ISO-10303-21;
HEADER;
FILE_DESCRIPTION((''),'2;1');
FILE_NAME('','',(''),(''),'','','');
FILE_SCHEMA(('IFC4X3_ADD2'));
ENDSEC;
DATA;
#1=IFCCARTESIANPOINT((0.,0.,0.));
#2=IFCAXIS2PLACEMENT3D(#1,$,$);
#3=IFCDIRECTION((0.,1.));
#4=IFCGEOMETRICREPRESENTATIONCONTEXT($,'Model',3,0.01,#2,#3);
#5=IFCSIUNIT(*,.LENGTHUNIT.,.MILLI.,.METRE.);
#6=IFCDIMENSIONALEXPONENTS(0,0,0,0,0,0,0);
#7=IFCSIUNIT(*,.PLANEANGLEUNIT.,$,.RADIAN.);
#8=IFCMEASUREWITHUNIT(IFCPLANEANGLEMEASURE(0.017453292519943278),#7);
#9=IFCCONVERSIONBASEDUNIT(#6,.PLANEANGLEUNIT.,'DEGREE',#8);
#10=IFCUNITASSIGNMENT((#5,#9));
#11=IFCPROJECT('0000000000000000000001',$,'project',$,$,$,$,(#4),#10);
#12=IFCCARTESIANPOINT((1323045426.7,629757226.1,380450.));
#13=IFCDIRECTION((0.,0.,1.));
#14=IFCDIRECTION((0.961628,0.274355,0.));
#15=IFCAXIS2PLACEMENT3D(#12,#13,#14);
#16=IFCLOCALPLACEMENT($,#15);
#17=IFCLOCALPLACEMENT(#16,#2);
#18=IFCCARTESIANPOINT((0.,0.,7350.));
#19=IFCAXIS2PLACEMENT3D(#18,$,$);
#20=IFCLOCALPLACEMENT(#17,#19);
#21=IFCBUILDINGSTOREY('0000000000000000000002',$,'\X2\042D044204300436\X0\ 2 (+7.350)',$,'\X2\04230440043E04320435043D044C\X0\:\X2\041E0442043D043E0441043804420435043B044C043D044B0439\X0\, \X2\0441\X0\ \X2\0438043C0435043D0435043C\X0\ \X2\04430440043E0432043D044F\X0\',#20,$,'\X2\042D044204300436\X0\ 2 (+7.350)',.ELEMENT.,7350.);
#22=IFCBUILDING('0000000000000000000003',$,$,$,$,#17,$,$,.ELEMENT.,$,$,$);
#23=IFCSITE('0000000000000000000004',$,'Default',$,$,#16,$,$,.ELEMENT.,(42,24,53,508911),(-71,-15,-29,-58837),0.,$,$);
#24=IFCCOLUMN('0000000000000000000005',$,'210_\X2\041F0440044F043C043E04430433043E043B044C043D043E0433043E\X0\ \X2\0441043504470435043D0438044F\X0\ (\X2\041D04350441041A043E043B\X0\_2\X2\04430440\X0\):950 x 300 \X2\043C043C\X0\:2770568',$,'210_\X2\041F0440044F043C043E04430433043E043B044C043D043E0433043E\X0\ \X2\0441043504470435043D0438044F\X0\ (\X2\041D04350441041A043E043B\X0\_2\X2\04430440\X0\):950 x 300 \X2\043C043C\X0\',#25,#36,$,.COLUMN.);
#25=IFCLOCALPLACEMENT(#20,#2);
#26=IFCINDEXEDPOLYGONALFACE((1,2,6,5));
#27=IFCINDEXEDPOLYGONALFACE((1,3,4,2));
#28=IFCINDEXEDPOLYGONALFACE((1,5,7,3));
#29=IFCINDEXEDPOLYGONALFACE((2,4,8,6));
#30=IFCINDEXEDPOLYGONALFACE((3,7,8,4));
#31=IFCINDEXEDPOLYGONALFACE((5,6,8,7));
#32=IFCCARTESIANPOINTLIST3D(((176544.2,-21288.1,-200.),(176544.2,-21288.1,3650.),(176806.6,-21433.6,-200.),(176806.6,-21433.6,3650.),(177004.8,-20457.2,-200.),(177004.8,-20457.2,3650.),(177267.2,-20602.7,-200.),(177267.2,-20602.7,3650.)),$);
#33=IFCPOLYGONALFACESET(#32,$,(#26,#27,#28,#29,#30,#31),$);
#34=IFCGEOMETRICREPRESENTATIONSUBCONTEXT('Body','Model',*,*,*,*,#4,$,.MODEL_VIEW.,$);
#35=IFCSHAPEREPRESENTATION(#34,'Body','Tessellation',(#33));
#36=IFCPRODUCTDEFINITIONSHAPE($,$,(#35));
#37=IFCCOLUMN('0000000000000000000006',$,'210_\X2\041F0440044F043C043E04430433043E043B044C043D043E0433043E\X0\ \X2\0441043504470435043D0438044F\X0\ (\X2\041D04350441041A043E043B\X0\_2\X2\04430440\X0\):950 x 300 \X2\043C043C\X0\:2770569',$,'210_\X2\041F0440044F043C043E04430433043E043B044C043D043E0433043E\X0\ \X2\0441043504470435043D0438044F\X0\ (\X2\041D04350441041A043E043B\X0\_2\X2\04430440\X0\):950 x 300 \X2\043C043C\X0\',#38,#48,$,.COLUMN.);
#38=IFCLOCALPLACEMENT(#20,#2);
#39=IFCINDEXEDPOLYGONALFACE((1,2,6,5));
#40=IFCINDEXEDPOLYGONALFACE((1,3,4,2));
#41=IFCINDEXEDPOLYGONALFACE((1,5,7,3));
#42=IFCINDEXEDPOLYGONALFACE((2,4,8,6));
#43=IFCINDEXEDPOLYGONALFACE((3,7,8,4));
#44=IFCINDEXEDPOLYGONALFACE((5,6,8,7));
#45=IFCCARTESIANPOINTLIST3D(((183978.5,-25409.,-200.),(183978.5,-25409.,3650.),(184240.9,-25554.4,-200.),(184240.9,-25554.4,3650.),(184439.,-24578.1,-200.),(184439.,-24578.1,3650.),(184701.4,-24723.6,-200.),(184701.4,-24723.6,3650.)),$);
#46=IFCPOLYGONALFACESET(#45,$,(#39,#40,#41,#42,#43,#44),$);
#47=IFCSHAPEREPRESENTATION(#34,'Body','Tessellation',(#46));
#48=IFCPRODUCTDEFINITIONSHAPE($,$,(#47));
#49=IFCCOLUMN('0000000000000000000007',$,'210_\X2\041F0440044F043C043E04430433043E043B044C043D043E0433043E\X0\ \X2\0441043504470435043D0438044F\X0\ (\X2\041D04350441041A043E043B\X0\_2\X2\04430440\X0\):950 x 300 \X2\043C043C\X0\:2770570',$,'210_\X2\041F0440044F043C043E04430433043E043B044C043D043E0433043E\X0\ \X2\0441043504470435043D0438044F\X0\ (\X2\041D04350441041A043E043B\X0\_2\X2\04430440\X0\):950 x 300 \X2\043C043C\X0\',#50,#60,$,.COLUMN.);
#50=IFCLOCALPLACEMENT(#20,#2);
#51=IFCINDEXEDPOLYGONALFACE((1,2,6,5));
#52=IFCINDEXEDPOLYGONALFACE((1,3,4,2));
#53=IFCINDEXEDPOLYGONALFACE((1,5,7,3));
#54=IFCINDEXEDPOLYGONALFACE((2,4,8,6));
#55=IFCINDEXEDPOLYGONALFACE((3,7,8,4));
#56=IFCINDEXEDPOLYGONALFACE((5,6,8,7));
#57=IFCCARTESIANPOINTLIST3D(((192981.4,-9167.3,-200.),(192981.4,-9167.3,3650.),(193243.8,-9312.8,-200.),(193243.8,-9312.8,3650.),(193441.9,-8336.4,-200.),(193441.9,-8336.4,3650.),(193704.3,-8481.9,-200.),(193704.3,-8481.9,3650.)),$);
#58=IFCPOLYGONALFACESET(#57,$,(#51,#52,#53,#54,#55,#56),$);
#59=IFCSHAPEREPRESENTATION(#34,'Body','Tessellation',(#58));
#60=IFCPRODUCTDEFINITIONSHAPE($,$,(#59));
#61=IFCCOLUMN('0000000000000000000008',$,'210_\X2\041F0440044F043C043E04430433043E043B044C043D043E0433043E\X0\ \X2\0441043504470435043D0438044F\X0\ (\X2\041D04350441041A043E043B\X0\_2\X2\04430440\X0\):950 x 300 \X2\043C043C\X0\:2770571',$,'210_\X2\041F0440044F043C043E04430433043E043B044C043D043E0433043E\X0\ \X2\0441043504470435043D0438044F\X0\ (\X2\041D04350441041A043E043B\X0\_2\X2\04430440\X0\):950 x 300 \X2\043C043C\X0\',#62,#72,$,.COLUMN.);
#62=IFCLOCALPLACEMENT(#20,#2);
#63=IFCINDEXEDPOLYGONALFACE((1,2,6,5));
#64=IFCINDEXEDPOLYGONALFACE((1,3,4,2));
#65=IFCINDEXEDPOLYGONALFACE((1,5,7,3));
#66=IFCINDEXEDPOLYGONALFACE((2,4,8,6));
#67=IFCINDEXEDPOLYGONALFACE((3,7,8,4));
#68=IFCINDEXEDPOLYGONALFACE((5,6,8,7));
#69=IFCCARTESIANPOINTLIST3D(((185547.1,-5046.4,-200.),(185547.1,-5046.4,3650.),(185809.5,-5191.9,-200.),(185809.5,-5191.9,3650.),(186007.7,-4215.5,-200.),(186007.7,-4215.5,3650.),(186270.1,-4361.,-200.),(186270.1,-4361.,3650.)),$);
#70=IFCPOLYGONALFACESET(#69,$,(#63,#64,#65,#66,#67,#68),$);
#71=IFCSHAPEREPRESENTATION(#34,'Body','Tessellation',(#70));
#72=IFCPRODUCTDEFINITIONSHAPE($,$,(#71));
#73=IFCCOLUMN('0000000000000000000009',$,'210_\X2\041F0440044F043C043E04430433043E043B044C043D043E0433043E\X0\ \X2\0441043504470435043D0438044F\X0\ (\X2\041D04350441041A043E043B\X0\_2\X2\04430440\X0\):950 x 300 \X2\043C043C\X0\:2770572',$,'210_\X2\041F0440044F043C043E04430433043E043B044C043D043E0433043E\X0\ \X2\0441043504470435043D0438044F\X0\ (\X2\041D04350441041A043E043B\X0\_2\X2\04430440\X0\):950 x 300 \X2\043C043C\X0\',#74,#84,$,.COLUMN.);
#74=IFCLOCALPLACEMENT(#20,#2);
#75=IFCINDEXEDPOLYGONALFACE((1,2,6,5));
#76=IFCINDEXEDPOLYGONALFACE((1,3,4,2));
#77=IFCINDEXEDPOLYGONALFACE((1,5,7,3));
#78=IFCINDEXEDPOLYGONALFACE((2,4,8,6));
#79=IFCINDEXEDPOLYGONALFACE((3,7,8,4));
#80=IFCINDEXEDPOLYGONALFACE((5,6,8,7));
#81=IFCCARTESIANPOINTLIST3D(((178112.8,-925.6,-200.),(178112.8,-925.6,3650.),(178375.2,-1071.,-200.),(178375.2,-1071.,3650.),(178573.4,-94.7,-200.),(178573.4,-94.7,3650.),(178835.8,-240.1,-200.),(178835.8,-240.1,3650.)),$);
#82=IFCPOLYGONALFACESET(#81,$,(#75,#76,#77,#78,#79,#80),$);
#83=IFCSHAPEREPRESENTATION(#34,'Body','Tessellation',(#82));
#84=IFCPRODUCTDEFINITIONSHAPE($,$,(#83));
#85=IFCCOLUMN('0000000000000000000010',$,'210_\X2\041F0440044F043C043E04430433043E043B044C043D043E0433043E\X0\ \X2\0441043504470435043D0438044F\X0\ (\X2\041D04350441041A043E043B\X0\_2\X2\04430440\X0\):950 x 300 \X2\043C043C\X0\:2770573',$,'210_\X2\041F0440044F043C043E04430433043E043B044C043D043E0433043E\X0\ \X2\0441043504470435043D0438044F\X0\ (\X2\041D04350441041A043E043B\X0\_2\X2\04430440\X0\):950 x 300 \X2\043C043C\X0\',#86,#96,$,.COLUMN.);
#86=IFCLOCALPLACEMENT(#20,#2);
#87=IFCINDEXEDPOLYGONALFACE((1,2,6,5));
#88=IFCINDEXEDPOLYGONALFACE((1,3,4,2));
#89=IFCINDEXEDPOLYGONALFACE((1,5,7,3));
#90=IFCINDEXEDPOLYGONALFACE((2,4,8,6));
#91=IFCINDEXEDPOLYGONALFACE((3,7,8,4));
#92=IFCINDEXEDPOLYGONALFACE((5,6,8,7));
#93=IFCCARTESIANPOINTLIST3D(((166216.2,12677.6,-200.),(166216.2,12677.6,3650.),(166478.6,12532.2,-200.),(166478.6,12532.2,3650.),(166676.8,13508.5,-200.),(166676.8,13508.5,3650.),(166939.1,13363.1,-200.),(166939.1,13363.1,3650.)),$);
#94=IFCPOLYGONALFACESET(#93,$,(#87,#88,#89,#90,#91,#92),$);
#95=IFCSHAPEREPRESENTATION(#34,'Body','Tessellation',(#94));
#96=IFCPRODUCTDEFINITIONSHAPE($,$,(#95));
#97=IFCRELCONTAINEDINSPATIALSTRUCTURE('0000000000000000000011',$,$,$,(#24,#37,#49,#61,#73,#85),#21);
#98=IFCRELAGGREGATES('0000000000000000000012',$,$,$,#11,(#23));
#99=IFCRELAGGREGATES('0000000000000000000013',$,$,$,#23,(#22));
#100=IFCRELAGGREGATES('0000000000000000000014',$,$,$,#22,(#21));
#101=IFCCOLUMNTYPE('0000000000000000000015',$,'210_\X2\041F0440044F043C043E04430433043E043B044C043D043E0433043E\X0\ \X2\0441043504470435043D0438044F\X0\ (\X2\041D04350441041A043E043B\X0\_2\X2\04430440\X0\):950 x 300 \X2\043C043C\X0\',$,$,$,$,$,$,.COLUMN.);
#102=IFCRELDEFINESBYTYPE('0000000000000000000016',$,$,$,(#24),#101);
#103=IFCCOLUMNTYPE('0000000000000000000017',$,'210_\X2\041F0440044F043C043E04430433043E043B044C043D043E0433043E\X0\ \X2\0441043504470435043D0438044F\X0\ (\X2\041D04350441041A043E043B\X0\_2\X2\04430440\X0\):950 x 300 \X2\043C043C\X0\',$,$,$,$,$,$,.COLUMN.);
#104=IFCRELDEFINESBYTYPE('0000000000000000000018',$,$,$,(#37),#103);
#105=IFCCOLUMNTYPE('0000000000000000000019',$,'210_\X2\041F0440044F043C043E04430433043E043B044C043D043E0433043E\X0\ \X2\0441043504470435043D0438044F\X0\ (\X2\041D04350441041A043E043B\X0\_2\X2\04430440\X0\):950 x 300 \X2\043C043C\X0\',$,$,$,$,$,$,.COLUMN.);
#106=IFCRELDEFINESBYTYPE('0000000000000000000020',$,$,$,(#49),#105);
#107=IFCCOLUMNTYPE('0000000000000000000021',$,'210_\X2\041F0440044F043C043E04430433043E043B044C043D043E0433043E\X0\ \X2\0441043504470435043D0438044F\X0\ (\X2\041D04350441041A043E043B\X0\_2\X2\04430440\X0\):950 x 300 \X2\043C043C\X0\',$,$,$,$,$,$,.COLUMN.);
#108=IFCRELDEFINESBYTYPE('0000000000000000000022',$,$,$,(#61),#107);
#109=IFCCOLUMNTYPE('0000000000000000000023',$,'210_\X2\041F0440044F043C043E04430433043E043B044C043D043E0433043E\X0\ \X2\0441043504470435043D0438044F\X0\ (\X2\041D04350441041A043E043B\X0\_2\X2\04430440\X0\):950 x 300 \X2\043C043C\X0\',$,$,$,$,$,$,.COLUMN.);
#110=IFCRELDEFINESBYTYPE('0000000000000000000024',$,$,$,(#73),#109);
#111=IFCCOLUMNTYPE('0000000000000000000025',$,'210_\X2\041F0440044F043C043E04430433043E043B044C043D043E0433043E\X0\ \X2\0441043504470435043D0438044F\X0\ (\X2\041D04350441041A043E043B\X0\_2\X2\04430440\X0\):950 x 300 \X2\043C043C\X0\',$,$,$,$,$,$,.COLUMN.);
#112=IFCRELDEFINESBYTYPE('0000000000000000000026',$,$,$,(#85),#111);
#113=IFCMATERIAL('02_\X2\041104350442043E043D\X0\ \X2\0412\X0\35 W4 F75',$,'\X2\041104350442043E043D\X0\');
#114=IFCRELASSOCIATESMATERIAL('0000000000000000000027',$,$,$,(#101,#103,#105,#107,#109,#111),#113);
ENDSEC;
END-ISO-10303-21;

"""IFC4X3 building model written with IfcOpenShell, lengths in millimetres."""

from ifc_helpers import new_model, entity, si_unit, converted_unit, direction, frame, frame_2d, origin, origin_2d_with_axis, place, context, subcontext, project, spatial, rectangle, extrude, source, transform, mapped, material, material_profile, profile_set, type_object, type_shapes, element, save


model = new_model("IFC4X3")

# Units and contexts
model_context = context("Model", 3, precision=0.01, world=origin(), true_north=direction((0.0, 1.0)))
body_context = subcontext(model_context, "Body", "Model", "MODEL_VIEW")
ifc_project = project(units=[si_unit("LENGTHUNIT", "METRE", prefix="MILLI"), converted_unit("PLANEANGLEUNIT", "DEGREE", entity("IfcPlaneAngleMeasure", 0.017453292519943278), si_unit("PLANEANGLEUNIT", "RADIAN"), dimensions=[0, 0, 0, 0, 0, 0, 0])], contexts=[model_context])

# Site, building, storey
site_placement = place(None, frame((1323045426.7, 629757226.1, 380450.0), z_axis=(0.0, 0.0, 1.0), x_axis=(0.961628, 0.274355, 0.0)))
site = spatial("IfcSite", under=ifc_project, at=site_placement, Name="Default", CompositionType="ELEMENT", RefLatitude=(42, 24, 53, 508911), RefLongitude=(-71, -15, -29, -58837), RefElevation=0.0)
building_placement = place(site_placement, origin())
building = spatial("IfcBuilding", under=site, at=building_placement, CompositionType="ELEMENT")
storey_placement = place(building_placement, frame((0.0, 0.0, 7350.0)))
storey = spatial("IfcBuildingStorey", under=building, at=storey_placement, Name="Этаж 2 (+7.350)", ObjectType="Уровень:Относительный, с именем уровня", LongName="Этаж 2 (+7.350)", CompositionType="ELEMENT", Elevation=7350.0)

# Columns
ifc_material = material(Name="02_Бетон В35 W4 F75", Category="Бетон")
ifc_material_profile_1 = material_profile(ifc_material, rectangle(XDim=300.0, YDim=950.0, at=origin_2d_with_axis()), Name="950 x 300 мм")
ifc_profile_set_1 = profile_set([ifc_material_profile_1], Name="950 x 300 мм")
column_type_1 = type_object("IfcColumnType", Name="210_Прямоугольного сечения (НесКол_2ур):950 x 300 мм", PredefinedType="COLUMN", material=ifc_profile_set_1)
shared_shape_1 = source(origin(), body_context, "Body", "SweptSolid", [
    extrude(rectangle(XDim=300.0, YDim=950.0, at=frame_2d((0.0, 0.0), x_axis=(1.0, 0.0))), frame((176905.7, -20945.4, 7150.0), z_axis=(0.0, 0.0, 1.0), x_axis=(-0.87462, 0.48481, 0.0)), (0.0, 0.0, 1.0), 3850.0),
])
type_shapes(column_type_1, [shared_shape_1])
column_1_placement = place(storey_placement, frame((0.0, 0.0, -7350.0)))
element("IfcColumn", 1, at=column_1_placement, inside=storey, type_object=column_type_1, Name="210_Прямоугольного сечения (НесКол_2ур):950 x 300 мм:2770568", ObjectType="210_Прямоугольного сечения (НесКол_2ур):950 x 300 мм", PredefinedType="COLUMN", context=body_context, shape_type="MappedRepresentation", body=[
    mapped(shared_shape_1, transform((0.0, 0.0, 0.0), scale=1.0)),
])
column_type_2 = type_object("IfcColumnType", Name="210_Прямоугольного сечения (НесКол_2ур):950 x 300 мм", PredefinedType="COLUMN", material=ifc_profile_set_1)
shared_shape_2 = source(origin(), body_context, "Body", "SweptSolid", [
    extrude(rectangle(XDim=300.0, YDim=950.0, at=frame_2d((0.0, 0.0), x_axis=(1.0, 0.0))), frame((184339.9, -25066.3, 7150.0), z_axis=(0.0, 0.0, 1.0), x_axis=(-0.87462, 0.48481, 0.0)), (0.0, 0.0, 1.0), 3850.0),
])
type_shapes(column_type_2, [shared_shape_2])
column_2_placement = place(storey_placement, frame((0.0, 0.0, -7350.0)))
element("IfcColumn", 2, at=column_2_placement, inside=storey, type_object=column_type_2, Name="210_Прямоугольного сечения (НесКол_2ур):950 x 300 мм:2770569", ObjectType="210_Прямоугольного сечения (НесКол_2ур):950 x 300 мм", PredefinedType="COLUMN", context=body_context, shape_type="MappedRepresentation", body=[
    mapped(shared_shape_2, transform((0.0, 0.0, 0.0), scale=1.0)),
])
column_type_3 = type_object("IfcColumnType", Name="210_Прямоугольного сечения (НесКол_2ур):950 x 300 мм", PredefinedType="COLUMN", material=ifc_profile_set_1)
shared_shape_3 = source(origin(), body_context, "Body", "SweptSolid", [
    extrude(rectangle(XDim=300.0, YDim=950.0, at=origin_2d_with_axis()), frame((193342.9, -8824.6, 7150.0), z_axis=(0.0, 0.0, 1.0), x_axis=(-0.87462, 0.48481, 0.0)), (0.0, 0.0, 1.0), 3850.0),
])
type_shapes(column_type_3, [shared_shape_3])
column_3_placement = place(storey_placement, frame((0.0, 0.0, -7350.0)))
element("IfcColumn", 3, at=column_3_placement, inside=storey, type_object=column_type_3, Name="210_Прямоугольного сечения (НесКол_2ур):950 x 300 мм:2770570", ObjectType="210_Прямоугольного сечения (НесКол_2ур):950 x 300 мм", PredefinedType="COLUMN", context=body_context, shape_type="MappedRepresentation", body=[
    mapped(shared_shape_3, transform((0.0, 0.0, 0.0), scale=1.0)),
])
column_type_4 = type_object("IfcColumnType", Name="210_Прямоугольного сечения (НесКол_2ур):950 x 300 мм", PredefinedType="COLUMN", material=ifc_profile_set_1)
shared_shape_4 = source(origin(), body_context, "Body", "SweptSolid", [
    extrude(rectangle(XDim=300.0, YDim=950.0, at=frame_2d((0.0, 0.0), x_axis=(1.0, 0.0))), frame((185908.6, -4703.7, 7150.0), z_axis=(0.0, 0.0, 1.0), x_axis=(-0.87462, 0.48481, 0.0)), (0.0, 0.0, 1.0), 3850.0),
])
type_shapes(column_type_4, [shared_shape_4])
column_4_placement = place(storey_placement, frame((0.0, 0.0, -7350.0)))
element("IfcColumn", 4, at=column_4_placement, inside=storey, type_object=column_type_4, Name="210_Прямоугольного сечения (НесКол_2ур):950 x 300 мм:2770571", ObjectType="210_Прямоугольного сечения (НесКол_2ур):950 x 300 мм", PredefinedType="COLUMN", context=body_context, shape_type="MappedRepresentation", body=[
    mapped(shared_shape_4, transform((0.0, 0.0, 0.0), scale=1.0)),
])
column_type_5 = type_object("IfcColumnType", Name="210_Прямоугольного сечения (НесКол_2ур):950 x 300 мм", PredefinedType="COLUMN", material=ifc_profile_set_1)
shared_shape_5 = source(origin(), body_context, "Body", "SweptSolid", [
    extrude(rectangle(XDim=300.0, YDim=950.0, at=frame_2d((0.0, 0.0), x_axis=(1.0, 0.0))), frame((178474.3, -582.8, 7150.0), z_axis=(0.0, 0.0, 1.0), x_axis=(-0.87462, 0.48481, 0.0)), (0.0, 0.0, 1.0), 3850.0),
])
type_shapes(column_type_5, [shared_shape_5])
column_5_placement = place(storey_placement, frame((0.0, 0.0, -7350.0)))
element("IfcColumn", 5, at=column_5_placement, inside=storey, type_object=column_type_5, Name="210_Прямоугольного сечения (НесКол_2ур):950 x 300 мм:2770572", ObjectType="210_Прямоугольного сечения (НесКол_2ур):950 x 300 мм", PredefinedType="COLUMN", context=body_context, shape_type="MappedRepresentation", body=[
    mapped(shared_shape_5, transform((0.0, 0.0, 0.0), scale=1.0)),
])
column_type_6 = type_object("IfcColumnType", Name="210_Прямоугольного сечения (НесКол_2ур):950 x 300 мм", PredefinedType="COLUMN", material=ifc_profile_set_1)
shared_shape_6 = source(origin(), body_context, "Body", "SweptSolid", [
    extrude(rectangle(XDim=300.0, YDim=950.0, at=frame_2d((0.0, 0.0), x_axis=(1.0, 0.0))), frame((166577.7, 13020.4, 7150.0), z_axis=(0.0, 0.0, 1.0), x_axis=(-0.87462, 0.48481, 0.0)), (0.0, 0.0, 1.0), 3850.0),
])
type_shapes(column_type_6, [shared_shape_6])
column_6_placement = place(storey_placement, frame((0.0, 0.0, -7350.0)))
element("IfcColumn", 6, at=column_6_placement, inside=storey, type_object=column_type_6, Name="210_Прямоугольного сечения (НесКол_2ур):950 x 300 мм:2770573", ObjectType="210_Прямоугольного сечения (НесКол_2ур):950 x 300 мм", PredefinedType="COLUMN", context=body_context, shape_type="MappedRepresentation", body=[
    mapped(shared_shape_6, transform((0.0, 0.0, 0.0), scale=1.0)),
])

save(model, "model.ifc")
